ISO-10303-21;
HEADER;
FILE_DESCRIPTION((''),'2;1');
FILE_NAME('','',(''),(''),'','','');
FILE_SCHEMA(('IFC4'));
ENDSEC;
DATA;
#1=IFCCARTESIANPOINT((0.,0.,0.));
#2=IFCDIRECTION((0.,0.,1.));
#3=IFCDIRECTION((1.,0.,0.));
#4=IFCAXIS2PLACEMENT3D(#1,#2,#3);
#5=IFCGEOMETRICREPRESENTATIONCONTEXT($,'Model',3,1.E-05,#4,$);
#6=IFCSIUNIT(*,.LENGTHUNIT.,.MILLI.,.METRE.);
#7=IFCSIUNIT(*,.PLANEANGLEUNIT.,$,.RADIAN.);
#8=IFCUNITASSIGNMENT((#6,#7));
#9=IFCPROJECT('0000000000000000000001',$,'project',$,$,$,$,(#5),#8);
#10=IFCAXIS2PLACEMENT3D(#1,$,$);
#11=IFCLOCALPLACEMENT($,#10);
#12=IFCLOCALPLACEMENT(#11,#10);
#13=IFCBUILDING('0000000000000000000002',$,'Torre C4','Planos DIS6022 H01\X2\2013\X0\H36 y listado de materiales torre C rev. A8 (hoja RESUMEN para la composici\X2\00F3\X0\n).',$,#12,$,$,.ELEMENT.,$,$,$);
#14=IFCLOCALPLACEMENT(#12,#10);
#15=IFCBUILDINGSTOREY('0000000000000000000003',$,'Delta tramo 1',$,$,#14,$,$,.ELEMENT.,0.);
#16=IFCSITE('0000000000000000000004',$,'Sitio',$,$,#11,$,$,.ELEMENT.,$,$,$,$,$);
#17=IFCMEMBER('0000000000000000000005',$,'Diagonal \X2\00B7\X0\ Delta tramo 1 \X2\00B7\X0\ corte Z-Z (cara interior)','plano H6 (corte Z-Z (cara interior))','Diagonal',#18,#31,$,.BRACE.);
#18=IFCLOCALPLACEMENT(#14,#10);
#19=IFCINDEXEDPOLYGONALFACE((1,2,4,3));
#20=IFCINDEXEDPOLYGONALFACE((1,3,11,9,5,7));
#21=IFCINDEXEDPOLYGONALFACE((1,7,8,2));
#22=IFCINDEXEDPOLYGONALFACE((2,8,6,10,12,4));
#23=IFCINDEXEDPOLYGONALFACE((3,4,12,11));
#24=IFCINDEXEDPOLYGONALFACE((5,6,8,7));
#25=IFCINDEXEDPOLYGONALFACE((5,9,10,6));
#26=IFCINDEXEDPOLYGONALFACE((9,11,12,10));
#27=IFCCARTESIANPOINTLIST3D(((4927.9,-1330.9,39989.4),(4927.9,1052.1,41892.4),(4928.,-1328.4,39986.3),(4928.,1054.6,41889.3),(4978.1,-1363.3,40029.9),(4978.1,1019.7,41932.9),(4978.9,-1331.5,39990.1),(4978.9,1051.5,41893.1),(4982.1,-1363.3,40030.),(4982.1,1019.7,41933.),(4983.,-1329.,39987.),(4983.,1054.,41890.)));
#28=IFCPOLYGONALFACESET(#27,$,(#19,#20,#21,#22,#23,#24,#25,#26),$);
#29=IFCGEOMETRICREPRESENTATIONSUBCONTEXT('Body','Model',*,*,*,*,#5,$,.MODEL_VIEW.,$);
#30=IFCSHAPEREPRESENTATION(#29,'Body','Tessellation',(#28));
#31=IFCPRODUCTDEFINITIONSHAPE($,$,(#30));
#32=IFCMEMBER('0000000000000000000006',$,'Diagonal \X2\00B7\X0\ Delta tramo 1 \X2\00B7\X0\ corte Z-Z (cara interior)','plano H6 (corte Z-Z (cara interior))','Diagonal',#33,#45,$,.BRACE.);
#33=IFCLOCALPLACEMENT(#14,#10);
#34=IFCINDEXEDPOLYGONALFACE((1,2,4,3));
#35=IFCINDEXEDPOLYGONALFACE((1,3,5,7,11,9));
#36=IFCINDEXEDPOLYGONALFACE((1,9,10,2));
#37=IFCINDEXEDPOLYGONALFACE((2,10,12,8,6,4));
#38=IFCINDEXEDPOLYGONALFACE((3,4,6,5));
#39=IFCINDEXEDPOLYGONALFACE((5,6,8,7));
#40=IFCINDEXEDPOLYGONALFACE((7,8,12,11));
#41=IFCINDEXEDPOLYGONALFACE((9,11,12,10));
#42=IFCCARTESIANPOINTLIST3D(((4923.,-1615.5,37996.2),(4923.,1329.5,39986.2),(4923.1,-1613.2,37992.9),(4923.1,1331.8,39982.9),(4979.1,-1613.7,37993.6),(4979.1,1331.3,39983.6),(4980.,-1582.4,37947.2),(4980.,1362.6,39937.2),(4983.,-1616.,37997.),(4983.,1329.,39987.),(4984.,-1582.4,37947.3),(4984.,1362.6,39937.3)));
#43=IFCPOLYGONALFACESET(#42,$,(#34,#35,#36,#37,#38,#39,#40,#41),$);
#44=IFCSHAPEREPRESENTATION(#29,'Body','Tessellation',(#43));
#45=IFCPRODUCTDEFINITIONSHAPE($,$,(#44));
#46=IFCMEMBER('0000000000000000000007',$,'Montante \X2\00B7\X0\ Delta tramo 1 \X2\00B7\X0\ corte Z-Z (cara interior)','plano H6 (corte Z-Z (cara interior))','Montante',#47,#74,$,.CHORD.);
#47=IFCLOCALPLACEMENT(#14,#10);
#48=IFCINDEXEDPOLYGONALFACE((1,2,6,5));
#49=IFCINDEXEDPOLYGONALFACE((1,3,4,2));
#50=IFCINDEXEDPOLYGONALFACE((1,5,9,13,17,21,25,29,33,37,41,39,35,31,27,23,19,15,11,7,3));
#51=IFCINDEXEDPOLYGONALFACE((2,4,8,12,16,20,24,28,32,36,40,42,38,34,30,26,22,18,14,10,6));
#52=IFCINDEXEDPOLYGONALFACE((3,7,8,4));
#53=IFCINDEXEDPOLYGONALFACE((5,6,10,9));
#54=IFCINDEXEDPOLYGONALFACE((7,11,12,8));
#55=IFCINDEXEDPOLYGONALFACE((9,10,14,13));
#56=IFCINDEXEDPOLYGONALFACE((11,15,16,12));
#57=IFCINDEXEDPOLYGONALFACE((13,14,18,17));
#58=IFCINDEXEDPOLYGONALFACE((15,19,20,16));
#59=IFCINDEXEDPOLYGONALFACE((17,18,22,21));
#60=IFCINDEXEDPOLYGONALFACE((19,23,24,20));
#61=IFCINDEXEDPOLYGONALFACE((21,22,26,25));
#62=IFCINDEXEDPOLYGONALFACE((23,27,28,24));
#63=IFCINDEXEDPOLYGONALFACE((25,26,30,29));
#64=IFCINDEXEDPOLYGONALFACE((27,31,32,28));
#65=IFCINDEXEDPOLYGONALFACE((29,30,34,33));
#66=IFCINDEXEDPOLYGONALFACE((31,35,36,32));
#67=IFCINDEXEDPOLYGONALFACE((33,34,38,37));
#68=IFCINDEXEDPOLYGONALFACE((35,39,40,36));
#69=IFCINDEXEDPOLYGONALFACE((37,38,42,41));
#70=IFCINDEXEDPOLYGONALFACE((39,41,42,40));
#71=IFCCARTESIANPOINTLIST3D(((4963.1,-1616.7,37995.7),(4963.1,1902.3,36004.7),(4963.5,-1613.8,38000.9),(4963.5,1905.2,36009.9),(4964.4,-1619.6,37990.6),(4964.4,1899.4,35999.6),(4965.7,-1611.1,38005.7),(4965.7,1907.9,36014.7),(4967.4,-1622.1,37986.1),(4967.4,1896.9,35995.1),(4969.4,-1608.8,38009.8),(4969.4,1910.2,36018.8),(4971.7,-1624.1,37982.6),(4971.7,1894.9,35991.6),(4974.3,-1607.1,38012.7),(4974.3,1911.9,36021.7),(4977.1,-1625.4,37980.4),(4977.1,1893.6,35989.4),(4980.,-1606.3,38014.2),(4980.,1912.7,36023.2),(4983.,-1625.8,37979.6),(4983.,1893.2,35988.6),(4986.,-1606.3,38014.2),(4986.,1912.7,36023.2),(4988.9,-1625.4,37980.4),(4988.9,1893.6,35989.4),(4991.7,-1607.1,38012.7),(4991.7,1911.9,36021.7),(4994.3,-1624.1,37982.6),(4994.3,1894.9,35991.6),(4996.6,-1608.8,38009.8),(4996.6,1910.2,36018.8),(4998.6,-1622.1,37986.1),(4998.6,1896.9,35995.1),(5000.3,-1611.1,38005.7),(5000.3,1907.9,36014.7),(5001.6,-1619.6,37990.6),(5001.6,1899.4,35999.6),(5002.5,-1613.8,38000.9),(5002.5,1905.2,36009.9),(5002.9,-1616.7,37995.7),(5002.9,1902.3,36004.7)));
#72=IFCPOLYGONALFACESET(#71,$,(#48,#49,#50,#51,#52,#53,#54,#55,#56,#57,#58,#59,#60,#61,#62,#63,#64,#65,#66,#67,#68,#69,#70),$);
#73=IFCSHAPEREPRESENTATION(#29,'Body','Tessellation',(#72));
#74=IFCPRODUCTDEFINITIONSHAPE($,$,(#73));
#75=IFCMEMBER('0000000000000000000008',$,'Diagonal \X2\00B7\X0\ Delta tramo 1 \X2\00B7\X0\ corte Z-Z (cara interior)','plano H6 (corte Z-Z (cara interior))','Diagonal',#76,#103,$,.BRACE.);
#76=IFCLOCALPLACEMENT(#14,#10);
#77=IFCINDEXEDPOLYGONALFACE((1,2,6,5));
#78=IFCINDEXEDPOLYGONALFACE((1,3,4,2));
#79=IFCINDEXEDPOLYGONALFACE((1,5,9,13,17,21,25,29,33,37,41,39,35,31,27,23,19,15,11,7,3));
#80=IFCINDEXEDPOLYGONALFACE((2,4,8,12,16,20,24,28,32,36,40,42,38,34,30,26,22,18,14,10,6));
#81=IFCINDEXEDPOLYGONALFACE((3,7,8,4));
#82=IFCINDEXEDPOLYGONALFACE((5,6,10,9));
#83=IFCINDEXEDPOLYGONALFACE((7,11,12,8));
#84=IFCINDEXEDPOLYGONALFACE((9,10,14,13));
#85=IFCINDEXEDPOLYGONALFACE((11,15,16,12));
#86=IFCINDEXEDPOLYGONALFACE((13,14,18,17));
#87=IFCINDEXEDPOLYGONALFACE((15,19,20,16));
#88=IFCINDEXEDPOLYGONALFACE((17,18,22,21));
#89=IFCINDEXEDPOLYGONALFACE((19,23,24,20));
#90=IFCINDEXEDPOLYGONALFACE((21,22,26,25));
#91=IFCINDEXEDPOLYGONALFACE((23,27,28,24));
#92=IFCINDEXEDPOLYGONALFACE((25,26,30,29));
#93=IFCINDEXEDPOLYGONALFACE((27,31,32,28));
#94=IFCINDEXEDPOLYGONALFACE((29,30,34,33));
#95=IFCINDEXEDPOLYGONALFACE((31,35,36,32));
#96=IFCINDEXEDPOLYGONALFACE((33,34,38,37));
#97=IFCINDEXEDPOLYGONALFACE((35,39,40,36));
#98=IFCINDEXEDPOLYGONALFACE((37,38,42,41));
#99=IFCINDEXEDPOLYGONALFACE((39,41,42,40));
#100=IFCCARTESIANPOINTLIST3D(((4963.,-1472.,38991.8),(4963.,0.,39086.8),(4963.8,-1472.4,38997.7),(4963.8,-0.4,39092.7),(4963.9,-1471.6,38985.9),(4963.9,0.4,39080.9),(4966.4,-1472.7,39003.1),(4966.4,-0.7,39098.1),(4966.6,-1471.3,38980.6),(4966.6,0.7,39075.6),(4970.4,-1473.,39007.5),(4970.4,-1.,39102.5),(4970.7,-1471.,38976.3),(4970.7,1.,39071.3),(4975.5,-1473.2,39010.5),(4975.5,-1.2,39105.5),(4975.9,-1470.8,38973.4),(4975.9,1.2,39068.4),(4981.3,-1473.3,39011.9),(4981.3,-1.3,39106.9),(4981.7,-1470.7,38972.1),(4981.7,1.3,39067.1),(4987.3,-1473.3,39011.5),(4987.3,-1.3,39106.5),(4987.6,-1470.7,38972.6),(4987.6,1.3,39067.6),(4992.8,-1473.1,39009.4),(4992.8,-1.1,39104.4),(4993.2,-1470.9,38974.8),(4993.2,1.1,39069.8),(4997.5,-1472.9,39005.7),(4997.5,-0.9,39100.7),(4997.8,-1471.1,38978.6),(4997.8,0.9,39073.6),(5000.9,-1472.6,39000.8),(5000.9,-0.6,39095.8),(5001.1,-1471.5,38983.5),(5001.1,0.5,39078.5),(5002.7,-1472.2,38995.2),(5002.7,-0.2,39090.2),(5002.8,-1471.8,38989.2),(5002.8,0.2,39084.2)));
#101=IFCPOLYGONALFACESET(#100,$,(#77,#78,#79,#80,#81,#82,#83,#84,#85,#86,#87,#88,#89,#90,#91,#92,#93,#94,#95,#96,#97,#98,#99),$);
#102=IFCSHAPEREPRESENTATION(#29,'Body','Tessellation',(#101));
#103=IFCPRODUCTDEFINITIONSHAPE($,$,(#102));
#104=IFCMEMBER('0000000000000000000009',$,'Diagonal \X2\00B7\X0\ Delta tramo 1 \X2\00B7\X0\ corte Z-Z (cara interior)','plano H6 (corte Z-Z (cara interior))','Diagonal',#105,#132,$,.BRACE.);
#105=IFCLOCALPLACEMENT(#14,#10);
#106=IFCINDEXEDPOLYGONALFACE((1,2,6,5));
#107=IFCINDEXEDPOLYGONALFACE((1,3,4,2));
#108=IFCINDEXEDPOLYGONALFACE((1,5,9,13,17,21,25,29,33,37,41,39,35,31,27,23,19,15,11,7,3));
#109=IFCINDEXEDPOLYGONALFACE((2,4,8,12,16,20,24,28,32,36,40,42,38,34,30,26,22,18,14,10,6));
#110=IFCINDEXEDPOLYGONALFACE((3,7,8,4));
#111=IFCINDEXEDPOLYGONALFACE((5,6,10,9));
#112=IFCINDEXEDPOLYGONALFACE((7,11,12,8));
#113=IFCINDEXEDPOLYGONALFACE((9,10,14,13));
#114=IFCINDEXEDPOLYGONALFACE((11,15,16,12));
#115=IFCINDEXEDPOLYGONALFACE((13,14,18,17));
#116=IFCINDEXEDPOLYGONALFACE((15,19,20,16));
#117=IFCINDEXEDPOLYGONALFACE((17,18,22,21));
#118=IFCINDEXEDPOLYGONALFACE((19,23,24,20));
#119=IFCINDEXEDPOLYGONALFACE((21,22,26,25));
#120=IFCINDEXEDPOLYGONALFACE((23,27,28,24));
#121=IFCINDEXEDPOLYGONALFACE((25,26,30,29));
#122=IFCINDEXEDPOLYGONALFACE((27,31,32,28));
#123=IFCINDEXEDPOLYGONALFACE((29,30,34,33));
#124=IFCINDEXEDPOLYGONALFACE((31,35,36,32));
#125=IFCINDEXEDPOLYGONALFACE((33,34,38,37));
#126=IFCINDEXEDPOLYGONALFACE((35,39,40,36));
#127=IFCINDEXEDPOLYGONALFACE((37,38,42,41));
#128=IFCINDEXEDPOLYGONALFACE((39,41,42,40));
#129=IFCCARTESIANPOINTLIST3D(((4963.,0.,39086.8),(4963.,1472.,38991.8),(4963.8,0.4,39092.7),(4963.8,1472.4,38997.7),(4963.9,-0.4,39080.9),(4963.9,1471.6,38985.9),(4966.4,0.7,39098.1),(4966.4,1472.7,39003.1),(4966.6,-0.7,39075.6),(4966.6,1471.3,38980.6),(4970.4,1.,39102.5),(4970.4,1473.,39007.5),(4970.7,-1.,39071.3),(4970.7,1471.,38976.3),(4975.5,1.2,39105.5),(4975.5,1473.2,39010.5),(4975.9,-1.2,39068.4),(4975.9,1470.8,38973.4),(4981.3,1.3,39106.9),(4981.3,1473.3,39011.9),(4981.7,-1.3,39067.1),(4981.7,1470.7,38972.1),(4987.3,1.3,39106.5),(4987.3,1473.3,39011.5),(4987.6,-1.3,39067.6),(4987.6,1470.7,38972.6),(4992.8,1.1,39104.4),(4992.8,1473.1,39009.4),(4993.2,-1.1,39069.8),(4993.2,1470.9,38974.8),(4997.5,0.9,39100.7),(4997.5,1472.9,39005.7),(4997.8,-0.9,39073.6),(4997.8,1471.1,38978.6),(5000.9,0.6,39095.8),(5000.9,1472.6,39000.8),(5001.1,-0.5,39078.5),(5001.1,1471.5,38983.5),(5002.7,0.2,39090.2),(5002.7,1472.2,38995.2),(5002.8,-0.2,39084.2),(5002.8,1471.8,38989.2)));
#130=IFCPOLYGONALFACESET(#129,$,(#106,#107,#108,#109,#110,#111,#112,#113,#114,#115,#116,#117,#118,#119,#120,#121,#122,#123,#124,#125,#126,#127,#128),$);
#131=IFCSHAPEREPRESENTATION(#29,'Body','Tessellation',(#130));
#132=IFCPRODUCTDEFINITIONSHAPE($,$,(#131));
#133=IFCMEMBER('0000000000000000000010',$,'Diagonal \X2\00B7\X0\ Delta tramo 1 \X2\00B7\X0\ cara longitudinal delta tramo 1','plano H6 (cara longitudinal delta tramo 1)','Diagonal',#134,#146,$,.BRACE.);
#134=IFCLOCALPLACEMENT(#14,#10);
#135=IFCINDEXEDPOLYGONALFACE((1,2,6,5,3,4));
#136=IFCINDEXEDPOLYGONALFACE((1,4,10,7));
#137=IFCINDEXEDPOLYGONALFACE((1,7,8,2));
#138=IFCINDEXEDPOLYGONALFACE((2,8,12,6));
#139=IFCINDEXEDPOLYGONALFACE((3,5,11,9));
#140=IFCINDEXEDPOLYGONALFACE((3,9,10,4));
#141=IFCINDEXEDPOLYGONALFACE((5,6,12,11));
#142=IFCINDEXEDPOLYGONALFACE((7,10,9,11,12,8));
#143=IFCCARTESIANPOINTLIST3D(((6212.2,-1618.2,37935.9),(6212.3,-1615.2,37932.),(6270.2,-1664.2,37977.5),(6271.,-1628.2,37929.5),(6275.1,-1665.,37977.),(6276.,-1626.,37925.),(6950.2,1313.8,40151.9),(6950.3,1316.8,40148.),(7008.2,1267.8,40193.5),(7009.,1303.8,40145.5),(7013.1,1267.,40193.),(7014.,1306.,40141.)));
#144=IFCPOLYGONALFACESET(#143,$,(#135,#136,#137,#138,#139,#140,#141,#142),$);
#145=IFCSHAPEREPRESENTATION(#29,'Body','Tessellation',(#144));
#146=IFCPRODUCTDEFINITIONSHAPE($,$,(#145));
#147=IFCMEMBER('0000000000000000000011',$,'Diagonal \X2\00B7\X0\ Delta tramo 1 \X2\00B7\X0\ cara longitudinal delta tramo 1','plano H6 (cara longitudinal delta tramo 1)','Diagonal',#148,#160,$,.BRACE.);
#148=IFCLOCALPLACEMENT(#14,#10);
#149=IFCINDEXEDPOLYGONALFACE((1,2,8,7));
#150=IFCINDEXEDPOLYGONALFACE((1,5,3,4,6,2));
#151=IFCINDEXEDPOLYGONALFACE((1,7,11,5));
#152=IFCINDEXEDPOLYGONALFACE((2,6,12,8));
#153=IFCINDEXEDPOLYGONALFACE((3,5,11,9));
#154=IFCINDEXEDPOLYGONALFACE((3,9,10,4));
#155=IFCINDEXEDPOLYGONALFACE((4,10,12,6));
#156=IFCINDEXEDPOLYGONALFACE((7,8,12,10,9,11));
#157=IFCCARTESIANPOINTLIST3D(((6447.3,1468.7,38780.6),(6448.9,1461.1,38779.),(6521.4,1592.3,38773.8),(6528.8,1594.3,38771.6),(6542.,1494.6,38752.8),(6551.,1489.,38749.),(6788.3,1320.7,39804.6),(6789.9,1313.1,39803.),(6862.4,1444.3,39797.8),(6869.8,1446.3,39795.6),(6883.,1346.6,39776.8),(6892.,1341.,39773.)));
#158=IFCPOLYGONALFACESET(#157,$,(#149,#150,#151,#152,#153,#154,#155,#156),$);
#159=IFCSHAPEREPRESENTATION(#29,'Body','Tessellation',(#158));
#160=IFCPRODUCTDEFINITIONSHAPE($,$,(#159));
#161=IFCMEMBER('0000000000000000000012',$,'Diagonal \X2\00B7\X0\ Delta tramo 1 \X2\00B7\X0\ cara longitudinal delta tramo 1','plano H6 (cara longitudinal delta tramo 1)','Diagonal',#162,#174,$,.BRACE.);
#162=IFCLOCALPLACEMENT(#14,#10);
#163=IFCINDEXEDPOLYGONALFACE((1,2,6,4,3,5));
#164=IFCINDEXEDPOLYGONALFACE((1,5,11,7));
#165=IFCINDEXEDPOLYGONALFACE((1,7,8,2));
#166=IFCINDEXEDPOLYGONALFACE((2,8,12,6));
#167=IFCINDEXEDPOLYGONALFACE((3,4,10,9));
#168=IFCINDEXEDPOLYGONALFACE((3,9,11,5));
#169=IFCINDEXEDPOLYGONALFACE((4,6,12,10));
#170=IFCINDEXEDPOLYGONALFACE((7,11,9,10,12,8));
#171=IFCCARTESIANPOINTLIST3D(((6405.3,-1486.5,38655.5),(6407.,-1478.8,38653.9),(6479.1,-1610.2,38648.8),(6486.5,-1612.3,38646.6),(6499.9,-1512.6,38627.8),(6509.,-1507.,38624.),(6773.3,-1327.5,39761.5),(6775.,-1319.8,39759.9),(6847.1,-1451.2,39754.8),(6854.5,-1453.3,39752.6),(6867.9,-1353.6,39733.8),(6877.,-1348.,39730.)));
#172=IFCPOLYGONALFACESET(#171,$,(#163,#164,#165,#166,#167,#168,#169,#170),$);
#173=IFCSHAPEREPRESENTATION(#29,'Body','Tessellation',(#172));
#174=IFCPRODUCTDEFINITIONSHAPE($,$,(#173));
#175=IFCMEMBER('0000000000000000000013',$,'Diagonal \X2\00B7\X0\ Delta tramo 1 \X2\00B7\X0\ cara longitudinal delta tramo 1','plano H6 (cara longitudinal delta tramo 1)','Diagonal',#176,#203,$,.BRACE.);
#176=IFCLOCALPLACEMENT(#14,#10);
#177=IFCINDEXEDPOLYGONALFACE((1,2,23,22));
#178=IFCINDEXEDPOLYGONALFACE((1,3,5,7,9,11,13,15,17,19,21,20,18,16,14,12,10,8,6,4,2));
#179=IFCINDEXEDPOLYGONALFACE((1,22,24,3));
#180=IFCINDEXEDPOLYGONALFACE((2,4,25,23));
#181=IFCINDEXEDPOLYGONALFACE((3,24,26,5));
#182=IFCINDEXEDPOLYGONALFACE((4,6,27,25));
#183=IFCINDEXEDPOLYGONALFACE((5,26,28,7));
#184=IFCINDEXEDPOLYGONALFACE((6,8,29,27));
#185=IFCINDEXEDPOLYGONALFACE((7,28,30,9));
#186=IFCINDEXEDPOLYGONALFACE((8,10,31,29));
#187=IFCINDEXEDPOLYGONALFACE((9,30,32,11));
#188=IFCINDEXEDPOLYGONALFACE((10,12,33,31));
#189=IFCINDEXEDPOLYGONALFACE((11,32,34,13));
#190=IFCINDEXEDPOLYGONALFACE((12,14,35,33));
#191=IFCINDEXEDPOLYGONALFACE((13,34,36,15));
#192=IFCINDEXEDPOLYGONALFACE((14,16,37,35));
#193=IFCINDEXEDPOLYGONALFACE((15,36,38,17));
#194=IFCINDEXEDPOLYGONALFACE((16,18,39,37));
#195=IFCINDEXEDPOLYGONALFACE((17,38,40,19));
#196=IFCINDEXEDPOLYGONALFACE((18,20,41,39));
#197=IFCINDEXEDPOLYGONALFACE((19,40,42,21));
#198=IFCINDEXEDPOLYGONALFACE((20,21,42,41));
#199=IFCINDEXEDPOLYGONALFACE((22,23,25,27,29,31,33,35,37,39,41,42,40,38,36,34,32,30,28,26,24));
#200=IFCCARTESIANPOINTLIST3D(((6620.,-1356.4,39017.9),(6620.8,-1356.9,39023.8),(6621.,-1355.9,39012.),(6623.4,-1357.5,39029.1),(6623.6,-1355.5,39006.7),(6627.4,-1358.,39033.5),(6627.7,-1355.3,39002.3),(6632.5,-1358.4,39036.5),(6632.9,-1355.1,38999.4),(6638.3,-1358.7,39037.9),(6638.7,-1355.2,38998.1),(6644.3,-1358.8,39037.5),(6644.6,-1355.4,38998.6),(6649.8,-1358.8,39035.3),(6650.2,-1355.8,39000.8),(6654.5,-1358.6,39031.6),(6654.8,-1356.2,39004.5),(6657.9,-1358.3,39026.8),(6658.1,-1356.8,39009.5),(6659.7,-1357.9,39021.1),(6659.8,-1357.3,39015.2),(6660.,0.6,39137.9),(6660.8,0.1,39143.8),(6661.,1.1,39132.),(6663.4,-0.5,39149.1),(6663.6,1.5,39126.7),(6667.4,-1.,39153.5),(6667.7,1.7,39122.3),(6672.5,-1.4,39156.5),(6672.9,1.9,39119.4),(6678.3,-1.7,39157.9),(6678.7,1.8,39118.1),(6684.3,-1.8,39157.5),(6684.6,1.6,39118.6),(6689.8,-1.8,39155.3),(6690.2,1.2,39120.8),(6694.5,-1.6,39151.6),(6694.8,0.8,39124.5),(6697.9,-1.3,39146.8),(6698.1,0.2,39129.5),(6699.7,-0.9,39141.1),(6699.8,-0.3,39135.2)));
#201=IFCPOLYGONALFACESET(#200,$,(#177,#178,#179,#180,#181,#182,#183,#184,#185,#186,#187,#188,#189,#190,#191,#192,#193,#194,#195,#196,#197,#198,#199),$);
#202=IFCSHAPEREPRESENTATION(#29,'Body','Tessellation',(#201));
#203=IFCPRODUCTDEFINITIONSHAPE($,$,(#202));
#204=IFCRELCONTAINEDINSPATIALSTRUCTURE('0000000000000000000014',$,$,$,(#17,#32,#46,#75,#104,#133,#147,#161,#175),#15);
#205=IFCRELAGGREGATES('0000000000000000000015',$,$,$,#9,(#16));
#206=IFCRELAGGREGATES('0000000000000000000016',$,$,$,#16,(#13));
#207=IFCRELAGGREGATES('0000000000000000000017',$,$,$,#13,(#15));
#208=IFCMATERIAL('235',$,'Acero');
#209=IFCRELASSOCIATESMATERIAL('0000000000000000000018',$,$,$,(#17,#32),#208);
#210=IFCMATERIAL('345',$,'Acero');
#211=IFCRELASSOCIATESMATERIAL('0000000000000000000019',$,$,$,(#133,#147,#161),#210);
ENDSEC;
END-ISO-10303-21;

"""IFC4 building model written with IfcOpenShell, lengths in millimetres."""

from ifc_helpers import new_model, si_unit, frame, frame_2d, origin, origin_with_axes, place, context, subcontext, project, spatial, circle, l_section, extrude, material, element, save


model = new_model("IFC4")

# Units and contexts
model_context = context("Model", 3, precision=1e-05, world=origin_with_axes())
body_context = subcontext(model_context, "Body", "Model", "MODEL_VIEW")
ifc_project = project(units=[si_unit("LENGTHUNIT", "METRE", prefix="MILLI"), si_unit("PLANEANGLEUNIT", "RADIAN")], contexts=[model_context])

# Site, building, storey
site_placement = place(None, origin())
site = spatial("IfcSite", under=ifc_project, at=site_placement, Name="Sitio", CompositionType="ELEMENT")
building_placement = place(site_placement, origin())
building = spatial("IfcBuilding", under=site, at=building_placement, Name="Torre C4", Description="Planos DIS6022 H01–H36 y listado de materiales torre C rev. A8 (hoja RESUMEN para la composición).", CompositionType="ELEMENT")
storey_placement = place(building_placement, origin())
storey = spatial("IfcBuildingStorey", under=building, at=storey_placement, Name="Delta tramo 1", CompositionType="ELEMENT", Elevation=0.0)

# Members
ifc_material_1 = material(Name="345", Category="Acero")
ifc_material_2 = material(Name="235", Category="Acero")
member_1_placement = place(storey_placement, frame((4983.0, -1329.0, 39987.0), z_axis=(0.0, 0.781412, 0.624015), x_axis=(-0.999852, 0.010743, -0.013453)))
element("IfcMember", 1, at=member_1_placement, inside=storey, material=ifc_material_2, Name="Diagonal · Delta tramo 1 · corte Z-Z (cara interior)", Description="plano H6 (corte Z-Z (cara interior))", ObjectType="Diagonal", PredefinedType="BRACE", context=body_context, shape_type="SweptSolid", body=[
    extrude(l_section(Depth=55.0, Width=55.0, Thickness=4.0, at=frame_2d((27.5, 27.5))), None, (0.0, 0.0, 1.0), 3049.6),
])
member_2_placement = place(storey_placement, frame((4983.0, 1329.0, 39987.0), z_axis=(0.0, -0.828571, -0.559884), x_axis=(-0.99987, 0.009026, -0.013358)))
element("IfcMember", 2, at=member_2_placement, inside=storey, material=ifc_material_2, Name="Diagonal · Delta tramo 1 · corte Z-Z (cara interior)", Description="plano H6 (corte Z-Z (cara interior))", ObjectType="Diagonal", PredefinedType="BRACE", context=body_context, shape_type="SweptSolid", body=[
    extrude(l_section(Depth=60.0, Width=60.0, Thickness=4.0, at=frame_2d((30.0, 30.0))), None, (0.0, 0.0, 1.0), 3554.3),
])
member_3_placement = place(storey_placement, frame((4983.0, -1616.0, 37997.0), z_axis=(0.0, 0.870351, -0.492432), x_axis=(0.0, -0.492432, -0.870351)))
element("IfcMember", 3, at=member_3_placement, inside=storey, Name="Montante · Delta tramo 1 · corte Z-Z (cara interior)", Description="plano H6 (corte Z-Z (cara interior))", ObjectType="Montante", PredefinedType="CHORD", context=body_context, shape_type="SweptSolid", body=[
    extrude(circle(Radius=20.0), None, (0.0, 0.0, 1.0), 4043.2),
])
for number, where, z_axis, x_axis, name in (
    (4, (4983.0, -1472.0, 38992.0), (0.0, 0.997924, 0.064404), (-0.999955, 0.000613, -0.009492), "Diagonal · Delta tramo 1 · corte Z-Z (cara interior)"),
    (5, (4983.0, 1472.0, 38992.0), (0.0, -0.997924, 0.064404), (-0.999955, -0.000613, -0.009492), "Diagonal · Delta tramo 1 · corte Z-Z (cara interior)"),
):
    element("IfcMember", number, at=place(storey_placement, frame(where, z_axis=z_axis, x_axis=x_axis)), inside=storey, Name=name, Description="plano H6 (corte Z-Z (cara interior))", ObjectType="Diagonal", PredefinedType="BRACE", context=body_context, shape_type="SweptSolid", body=[
        extrude(circle(Radius=20.0), None, (0.0, 0.0, 1.0), 1475.1),
    ])
member_4_placement = place(storey_placement, frame((6276.0, -1626.0, 37925.0), z_axis=(0.196874, 0.782161, 0.591156), x_axis=(-0.980322, 0.165937, 0.106927)))
element("IfcMember", 6, at=member_4_placement, inside=storey, material=ifc_material_1, Name="Diagonal · Delta tramo 1 · cara longitudinal delta tramo 1", Description="plano H6 (cara longitudinal delta tramo 1)", ObjectType="Diagonal", PredefinedType="BRACE", context=body_context, shape_type="SweptSolid", body=[
    extrude(l_section(Depth=65.0, Width=65.0, Thickness=5.0, at=frame_2d((32.5, 32.5))), None, (0.0, 0.0, 1.0), 3748.6),
])
member_5_placement = place(storey_placement, frame((6892.0, 1341.0, 39773.0), z_axis=(-0.31302, 0.135856, -0.939979), x_axis=(-0.928102, -0.253844, 0.272377)))
element("IfcMember", 7, at=member_5_placement, inside=storey, material=ifc_material_1, Name="Diagonal · Delta tramo 1 · cara longitudinal delta tramo 1", Description="plano H6 (cara longitudinal delta tramo 1)", ObjectType="Diagonal", PredefinedType="BRACE", context=body_context, shape_type="SweptSolid", body=[
    extrude(l_section(Depth=110.0, Width=110.0, Thickness=8.0, at=frame_2d((55.0, 55.0))), None, (0.0, 0.0, 1.0), 1089.4),
])
member_6_placement = place(storey_placement, frame((6509.0, -1507.0, 38624.0), z_axis=(0.312816, 0.135157, 0.940148), x_axis=(-0.927617, 0.25621, 0.271813)))
element("IfcMember", 8, at=member_6_placement, inside=storey, material=ifc_material_1, Name="Diagonal · Delta tramo 1 · cara longitudinal delta tramo 1", Description="plano H6 (cara longitudinal delta tramo 1)", ObjectType="Diagonal", PredefinedType="BRACE", context=body_context, shape_type="SweptSolid", body=[
    extrude(l_section(Depth=110.0, Width=110.0, Thickness=8.0, at=frame_2d((55.0, 55.0))), None, (0.0, 0.0, 1.0), 1176.4),
])
for number, where, z_axis, x_axis, name in (
    (9, (6680.0, 0.0, 39138.0), (-0.02935, -0.995684, -0.088049), (-0.999529, 0.030023, -0.006331), "Diagonal · Delta tramo 1 · cara longitudinal delta tramo 1"),
):
    element("IfcMember", number, at=place(storey_placement, frame(where, z_axis=z_axis, x_axis=x_axis)), inside=storey, Name=name, Description="plano H6 (cara longitudinal delta tramo 1)", ObjectType="Diagonal", PredefinedType="BRACE", context=body_context, shape_type="SweptSolid", body=[
        extrude(circle(Radius=20.0), None, (0.0, 0.0, 1.0), 1362.9),
    ])

save(model, "model.ifc")
